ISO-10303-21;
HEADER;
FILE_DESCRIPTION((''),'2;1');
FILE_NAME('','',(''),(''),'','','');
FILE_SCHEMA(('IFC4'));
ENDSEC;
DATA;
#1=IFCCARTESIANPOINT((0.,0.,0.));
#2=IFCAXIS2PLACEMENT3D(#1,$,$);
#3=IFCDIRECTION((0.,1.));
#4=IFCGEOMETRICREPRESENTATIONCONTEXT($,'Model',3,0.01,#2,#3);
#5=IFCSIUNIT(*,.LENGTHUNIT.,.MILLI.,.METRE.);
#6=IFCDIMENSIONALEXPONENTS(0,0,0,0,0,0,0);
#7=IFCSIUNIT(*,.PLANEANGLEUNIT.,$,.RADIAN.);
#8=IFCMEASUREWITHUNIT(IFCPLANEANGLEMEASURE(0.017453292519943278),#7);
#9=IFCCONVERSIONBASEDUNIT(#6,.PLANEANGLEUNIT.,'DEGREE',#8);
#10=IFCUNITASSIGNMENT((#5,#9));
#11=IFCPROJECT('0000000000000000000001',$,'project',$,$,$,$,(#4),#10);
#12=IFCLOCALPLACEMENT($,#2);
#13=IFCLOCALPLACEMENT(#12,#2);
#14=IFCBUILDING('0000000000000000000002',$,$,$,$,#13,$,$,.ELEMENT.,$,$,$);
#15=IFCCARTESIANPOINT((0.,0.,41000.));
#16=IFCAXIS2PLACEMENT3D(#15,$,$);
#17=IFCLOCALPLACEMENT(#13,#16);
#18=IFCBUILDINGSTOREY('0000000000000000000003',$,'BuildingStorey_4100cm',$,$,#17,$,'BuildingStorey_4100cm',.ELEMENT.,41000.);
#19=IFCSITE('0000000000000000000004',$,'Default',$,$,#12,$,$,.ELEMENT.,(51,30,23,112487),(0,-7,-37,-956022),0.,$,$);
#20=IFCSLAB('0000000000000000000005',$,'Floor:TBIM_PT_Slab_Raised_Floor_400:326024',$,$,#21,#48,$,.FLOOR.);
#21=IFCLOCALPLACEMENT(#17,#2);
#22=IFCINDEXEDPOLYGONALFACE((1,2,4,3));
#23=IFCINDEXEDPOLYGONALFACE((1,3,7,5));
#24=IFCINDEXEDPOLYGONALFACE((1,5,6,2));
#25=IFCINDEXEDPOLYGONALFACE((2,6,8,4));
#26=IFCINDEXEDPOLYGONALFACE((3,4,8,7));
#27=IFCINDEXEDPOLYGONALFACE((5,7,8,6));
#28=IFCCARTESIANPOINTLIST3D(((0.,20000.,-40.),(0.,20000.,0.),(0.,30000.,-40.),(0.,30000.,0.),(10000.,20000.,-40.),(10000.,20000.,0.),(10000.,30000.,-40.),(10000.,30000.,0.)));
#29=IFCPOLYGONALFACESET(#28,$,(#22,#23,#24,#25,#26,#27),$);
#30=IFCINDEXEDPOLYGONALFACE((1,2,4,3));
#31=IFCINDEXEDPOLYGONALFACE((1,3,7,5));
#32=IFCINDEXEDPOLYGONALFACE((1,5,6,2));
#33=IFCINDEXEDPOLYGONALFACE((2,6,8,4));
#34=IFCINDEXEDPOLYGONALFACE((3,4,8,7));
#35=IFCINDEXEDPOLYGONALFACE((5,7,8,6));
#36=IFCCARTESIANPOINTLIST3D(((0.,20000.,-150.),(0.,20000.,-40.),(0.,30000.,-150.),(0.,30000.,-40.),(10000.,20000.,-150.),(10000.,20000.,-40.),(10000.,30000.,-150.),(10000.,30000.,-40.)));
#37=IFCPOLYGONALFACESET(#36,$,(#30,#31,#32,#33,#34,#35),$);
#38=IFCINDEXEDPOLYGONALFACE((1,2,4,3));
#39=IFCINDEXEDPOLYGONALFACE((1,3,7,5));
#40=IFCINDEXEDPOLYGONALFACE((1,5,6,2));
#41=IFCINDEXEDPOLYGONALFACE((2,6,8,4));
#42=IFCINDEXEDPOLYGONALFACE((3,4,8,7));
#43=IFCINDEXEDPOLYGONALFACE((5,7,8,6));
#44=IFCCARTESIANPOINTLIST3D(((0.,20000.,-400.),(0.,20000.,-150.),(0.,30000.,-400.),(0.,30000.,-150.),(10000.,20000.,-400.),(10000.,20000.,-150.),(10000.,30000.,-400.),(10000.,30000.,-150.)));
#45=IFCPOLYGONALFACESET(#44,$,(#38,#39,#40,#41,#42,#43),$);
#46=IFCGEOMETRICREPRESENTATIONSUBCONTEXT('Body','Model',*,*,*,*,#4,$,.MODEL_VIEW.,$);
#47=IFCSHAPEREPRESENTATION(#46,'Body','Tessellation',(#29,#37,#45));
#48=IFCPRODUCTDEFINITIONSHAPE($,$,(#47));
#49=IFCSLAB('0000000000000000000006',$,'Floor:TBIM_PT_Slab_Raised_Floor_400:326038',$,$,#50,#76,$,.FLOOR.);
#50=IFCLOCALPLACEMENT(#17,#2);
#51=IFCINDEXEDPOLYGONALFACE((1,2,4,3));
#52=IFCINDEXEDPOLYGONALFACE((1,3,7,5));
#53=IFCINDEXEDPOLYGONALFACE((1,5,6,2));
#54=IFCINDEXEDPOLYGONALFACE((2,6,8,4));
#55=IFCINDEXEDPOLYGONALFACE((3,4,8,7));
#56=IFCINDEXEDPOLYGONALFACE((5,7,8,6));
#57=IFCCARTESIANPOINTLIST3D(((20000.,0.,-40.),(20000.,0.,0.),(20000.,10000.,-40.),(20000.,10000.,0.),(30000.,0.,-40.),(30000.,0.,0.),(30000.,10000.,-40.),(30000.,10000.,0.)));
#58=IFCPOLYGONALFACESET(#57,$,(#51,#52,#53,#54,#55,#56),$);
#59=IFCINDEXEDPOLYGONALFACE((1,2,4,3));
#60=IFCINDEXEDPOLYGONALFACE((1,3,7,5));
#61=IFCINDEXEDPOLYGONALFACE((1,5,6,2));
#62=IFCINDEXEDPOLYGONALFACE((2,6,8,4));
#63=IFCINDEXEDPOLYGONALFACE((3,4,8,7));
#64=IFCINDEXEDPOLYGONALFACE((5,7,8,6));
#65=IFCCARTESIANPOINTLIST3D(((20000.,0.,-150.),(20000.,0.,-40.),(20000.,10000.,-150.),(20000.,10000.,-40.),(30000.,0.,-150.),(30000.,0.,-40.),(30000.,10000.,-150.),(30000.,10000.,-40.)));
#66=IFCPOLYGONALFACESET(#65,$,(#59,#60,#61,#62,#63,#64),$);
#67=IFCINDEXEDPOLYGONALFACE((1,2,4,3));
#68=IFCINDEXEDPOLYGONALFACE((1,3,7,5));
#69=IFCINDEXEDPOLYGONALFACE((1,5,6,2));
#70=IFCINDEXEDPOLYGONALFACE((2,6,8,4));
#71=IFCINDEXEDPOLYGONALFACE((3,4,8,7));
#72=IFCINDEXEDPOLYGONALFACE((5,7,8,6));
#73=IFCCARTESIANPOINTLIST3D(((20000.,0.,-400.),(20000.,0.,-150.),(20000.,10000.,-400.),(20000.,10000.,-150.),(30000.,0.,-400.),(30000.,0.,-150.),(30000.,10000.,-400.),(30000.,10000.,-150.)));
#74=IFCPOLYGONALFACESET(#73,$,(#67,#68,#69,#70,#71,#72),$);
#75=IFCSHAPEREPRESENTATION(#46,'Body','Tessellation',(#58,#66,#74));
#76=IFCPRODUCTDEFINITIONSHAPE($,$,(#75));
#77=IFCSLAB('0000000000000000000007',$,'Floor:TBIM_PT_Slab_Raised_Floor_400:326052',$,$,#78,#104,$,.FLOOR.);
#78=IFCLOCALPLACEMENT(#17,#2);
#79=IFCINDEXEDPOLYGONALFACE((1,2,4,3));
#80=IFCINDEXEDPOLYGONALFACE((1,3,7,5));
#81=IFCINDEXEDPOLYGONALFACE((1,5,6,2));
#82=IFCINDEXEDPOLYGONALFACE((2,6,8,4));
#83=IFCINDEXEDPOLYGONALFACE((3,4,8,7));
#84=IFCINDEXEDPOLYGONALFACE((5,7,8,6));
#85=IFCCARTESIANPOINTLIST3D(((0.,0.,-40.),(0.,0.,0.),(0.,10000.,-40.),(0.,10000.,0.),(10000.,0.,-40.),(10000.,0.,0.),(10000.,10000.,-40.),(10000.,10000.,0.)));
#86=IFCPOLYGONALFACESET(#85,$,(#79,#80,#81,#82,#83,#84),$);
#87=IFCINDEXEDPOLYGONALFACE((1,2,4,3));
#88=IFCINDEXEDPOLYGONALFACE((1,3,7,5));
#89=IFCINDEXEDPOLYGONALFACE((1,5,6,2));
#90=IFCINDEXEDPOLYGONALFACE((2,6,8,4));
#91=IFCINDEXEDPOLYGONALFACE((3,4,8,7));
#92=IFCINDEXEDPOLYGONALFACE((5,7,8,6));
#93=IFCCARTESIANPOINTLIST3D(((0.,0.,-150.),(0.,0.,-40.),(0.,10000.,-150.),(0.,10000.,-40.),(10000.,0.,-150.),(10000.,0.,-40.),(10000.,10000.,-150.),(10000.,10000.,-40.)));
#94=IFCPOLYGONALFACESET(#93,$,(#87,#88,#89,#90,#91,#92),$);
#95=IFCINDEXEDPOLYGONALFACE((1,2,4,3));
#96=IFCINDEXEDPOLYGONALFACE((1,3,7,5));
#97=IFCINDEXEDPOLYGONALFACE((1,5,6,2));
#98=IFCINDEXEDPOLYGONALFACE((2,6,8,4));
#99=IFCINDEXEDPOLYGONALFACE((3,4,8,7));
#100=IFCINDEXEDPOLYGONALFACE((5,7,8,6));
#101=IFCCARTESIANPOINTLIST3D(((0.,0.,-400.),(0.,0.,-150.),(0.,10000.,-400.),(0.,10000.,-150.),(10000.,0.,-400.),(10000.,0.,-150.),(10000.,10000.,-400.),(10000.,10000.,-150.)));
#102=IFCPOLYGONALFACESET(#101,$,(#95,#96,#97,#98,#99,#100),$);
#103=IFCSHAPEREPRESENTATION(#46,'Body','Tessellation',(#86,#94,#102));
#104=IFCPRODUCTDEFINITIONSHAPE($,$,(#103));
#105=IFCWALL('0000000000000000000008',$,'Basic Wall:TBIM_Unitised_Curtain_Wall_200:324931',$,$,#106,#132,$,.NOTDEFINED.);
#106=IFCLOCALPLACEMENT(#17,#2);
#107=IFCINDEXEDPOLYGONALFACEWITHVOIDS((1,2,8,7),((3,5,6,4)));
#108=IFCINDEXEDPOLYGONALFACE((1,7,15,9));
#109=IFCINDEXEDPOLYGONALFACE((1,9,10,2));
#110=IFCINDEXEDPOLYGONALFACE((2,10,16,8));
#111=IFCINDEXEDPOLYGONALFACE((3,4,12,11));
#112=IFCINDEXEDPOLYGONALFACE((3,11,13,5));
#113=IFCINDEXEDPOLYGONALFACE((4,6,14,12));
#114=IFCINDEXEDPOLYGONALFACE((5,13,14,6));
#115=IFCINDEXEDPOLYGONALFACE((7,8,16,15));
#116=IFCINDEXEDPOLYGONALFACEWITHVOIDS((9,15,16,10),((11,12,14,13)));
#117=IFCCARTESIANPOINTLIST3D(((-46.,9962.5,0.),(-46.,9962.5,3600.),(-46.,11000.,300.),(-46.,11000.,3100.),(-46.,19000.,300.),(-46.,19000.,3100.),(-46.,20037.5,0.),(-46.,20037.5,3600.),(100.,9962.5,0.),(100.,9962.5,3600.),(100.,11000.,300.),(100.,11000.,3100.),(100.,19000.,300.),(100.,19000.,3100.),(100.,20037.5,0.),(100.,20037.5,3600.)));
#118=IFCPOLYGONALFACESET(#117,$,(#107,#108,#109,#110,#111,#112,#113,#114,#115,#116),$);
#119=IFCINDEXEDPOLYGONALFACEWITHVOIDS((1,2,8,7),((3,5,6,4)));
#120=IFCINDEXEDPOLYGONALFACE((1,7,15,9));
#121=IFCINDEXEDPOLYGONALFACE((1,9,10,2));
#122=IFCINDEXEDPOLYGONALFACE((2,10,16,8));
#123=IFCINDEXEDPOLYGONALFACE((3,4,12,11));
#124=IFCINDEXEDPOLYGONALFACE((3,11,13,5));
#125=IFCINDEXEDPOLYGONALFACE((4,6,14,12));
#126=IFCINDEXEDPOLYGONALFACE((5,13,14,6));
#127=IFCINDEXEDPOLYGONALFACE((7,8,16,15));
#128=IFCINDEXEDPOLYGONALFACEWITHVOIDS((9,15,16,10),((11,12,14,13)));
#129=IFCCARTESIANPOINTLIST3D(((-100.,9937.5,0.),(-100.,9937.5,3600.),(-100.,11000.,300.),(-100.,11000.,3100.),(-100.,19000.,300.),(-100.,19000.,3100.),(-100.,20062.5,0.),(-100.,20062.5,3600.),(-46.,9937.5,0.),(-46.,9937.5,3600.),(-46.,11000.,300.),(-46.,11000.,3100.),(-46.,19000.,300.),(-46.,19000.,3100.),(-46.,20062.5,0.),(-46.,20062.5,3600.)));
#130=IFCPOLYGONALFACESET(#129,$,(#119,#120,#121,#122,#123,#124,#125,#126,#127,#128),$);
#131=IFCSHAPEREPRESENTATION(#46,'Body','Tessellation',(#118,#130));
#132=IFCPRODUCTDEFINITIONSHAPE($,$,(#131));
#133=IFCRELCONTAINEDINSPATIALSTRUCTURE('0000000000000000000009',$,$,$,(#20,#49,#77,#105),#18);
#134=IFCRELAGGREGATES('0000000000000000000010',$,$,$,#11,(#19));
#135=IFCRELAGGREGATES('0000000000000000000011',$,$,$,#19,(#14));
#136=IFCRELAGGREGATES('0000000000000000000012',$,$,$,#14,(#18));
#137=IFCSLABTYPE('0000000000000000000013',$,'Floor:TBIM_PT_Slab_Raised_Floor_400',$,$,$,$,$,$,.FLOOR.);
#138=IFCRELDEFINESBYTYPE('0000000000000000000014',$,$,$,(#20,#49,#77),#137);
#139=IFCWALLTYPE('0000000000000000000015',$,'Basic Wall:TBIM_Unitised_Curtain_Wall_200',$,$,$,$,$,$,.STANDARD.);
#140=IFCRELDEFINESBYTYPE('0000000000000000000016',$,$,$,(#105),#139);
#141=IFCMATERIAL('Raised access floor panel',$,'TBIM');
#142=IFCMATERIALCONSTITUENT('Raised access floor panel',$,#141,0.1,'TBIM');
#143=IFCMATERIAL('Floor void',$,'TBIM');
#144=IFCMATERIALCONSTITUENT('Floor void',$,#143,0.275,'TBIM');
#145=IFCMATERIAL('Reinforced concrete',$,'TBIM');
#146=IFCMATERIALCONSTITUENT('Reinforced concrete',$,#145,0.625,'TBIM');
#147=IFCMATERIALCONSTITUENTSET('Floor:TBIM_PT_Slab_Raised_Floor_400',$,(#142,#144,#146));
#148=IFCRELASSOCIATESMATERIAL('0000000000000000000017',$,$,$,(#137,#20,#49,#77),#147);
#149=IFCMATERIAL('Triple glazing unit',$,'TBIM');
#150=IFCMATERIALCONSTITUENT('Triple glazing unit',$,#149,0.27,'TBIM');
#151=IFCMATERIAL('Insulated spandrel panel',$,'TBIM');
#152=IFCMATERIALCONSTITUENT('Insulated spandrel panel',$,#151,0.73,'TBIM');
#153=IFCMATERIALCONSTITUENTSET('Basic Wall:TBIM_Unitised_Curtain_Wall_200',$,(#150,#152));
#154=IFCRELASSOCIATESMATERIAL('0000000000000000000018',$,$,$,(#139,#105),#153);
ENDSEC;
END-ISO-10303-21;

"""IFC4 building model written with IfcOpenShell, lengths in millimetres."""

from ifc_helpers import new_model, entity, si_unit, converted_unit, direction, frame, origin, place, context, subcontext, project, spatial, indexed_curve, outline, extrude, material, constituent, constituent_set, type_object, element, save


model = new_model("IFC4")

# Units and contexts
model_context = context("Model", 3, precision=0.01, world=origin(), true_north=direction((0.0, 1.0)))
body_context = subcontext(model_context, "Body", "Model", "MODEL_VIEW")
ifc_project = project(units=[si_unit("LENGTHUNIT", "METRE", prefix="MILLI"), converted_unit("PLANEANGLEUNIT", "DEGREE", entity("IfcPlaneAngleMeasure", 0.017453292519943278), si_unit("PLANEANGLEUNIT", "RADIAN"), dimensions=[0, 0, 0, 0, 0, 0, 0])], contexts=[model_context])

# Site, building, storey
site_placement = place(None, origin())
site = spatial("IfcSite", under=ifc_project, at=site_placement, Name="Default", CompositionType="ELEMENT", RefLatitude=(51, 30, 23, 112487), RefLongitude=(0, -7, -37, -956022), RefElevation=0.0)
building_placement = place(site_placement, origin())
building = spatial("IfcBuilding", under=site, at=building_placement, CompositionType="ELEMENT")
storey_placement = place(building_placement, frame((0.0, 0.0, 41000.0)))
storey = spatial("IfcBuildingStorey", under=building, at=storey_placement, Name="BuildingStorey_4100cm", LongName="BuildingStorey_4100cm", CompositionType="ELEMENT", Elevation=41000.0)

# Slabs
ifc_material_1 = material(Name="Raised access floor panel", Category="TBIM")
ifc_constituent_1 = constituent(ifc_material_1, Name="Raised access floor panel", Category="TBIM", fraction=0.1)
ifc_material_2 = material(Name="Floor void", Category="TBIM")
ifc_constituent_2 = constituent(ifc_material_2, Name="Floor void", Category="TBIM", fraction=0.275)
ifc_material_3 = material(Name="Reinforced concrete", Category="TBIM")
ifc_constituent_3 = constituent(ifc_material_3, Name="Reinforced concrete", Category="TBIM", fraction=0.625)
ifc_constituent_set_1 = constituent_set(constituents=[ifc_constituent_1, ifc_constituent_2, ifc_constituent_3], Name="Floor:TBIM_PT_Slab_Raised_Floor_400")
slab_type = type_object("IfcSlabType", Name="Floor:TBIM_PT_Slab_Raised_Floor_400", PredefinedType="FLOOR", material=ifc_constituent_set_1)
slab_1_placement = place(storey_placement, origin())
element("IfcSlab", 1, at=slab_1_placement, inside=storey, type_object=slab_type, material=ifc_constituent_set_1, Name="Floor:TBIM_PT_Slab_Raised_Floor_400:326024", PredefinedType="FLOOR", context=body_context, shape_type="SweptSolid", body=[
    extrude(outline(indexed_curve([(-5000.0, -5000.0), (5000.0, -5000.0), (5000.0, 5000.0), (-5000.0, 5000.0), (-5000.0, -5000.0)], self_intersect=False)), frame((5000.0, 25000.0, -40.0), z_axis=(0.0, 0.0, 1.0), x_axis=(-1.0, 0.0, 0.0)), (0.0, 0.0, 1.0), 40.0),
    extrude(outline(indexed_curve([(-5000.0, -5000.0), (5000.0, -5000.0), (5000.0, 5000.0), (-5000.0, 5000.0), (-5000.0, -5000.0)], self_intersect=False)), frame((5000.0, 25000.0, -150.0), z_axis=(0.0, 0.0, 1.0), x_axis=(-1.0, 0.0, 0.0)), (0.0, 0.0, 1.0), 110.0),
    extrude(outline(indexed_curve([(-5000.0, -5000.0), (5000.0, -5000.0), (5000.0, 5000.0), (-5000.0, 5000.0), (-5000.0, -5000.0)], self_intersect=False)), frame((5000.0, 25000.0, -400.0), z_axis=(0.0, 0.0, 1.0), x_axis=(-1.0, 0.0, 0.0)), (0.0, 0.0, 1.0), 250.0),
])
slab_2_placement = place(storey_placement, origin())
element("IfcSlab", 2, at=slab_2_placement, inside=storey, type_object=slab_type, material=ifc_constituent_set_1, Name="Floor:TBIM_PT_Slab_Raised_Floor_400:326038", PredefinedType="FLOOR", context=body_context, shape_type="SweptSolid", body=[
    extrude(outline(indexed_curve([(-5000.0, -5000.0), (5000.0, -5000.0), (5000.0, 5000.0), (-5000.0, 5000.0), (-5000.0, -5000.0)], self_intersect=False)), frame((25000.0, 5000.0, -40.0), z_axis=(0.0, 0.0, 1.0), x_axis=(-1.0, 0.0, 0.0)), (0.0, 0.0, 1.0), 40.0),
    extrude(outline(indexed_curve([(-5000.0, -5000.0), (5000.0, -5000.0), (5000.0, 5000.0), (-5000.0, 5000.0), (-5000.0, -5000.0)], self_intersect=False)), frame((25000.0, 5000.0, -150.0), z_axis=(0.0, 0.0, 1.0), x_axis=(-1.0, 0.0, 0.0)), (0.0, 0.0, 1.0), 110.0),
    extrude(outline(indexed_curve([(-5000.0, -5000.0), (5000.0, -5000.0), (5000.0, 5000.0), (-5000.0, 5000.0), (-5000.0, -5000.0)], self_intersect=False)), frame((25000.0, 5000.0, -400.0), z_axis=(0.0, 0.0, 1.0), x_axis=(-1.0, 0.0, 0.0)), (0.0, 0.0, 1.0), 250.0),
])
slab_3_placement = place(storey_placement, origin())
element("IfcSlab", 3, at=slab_3_placement, inside=storey, type_object=slab_type, material=ifc_constituent_set_1, Name="Floor:TBIM_PT_Slab_Raised_Floor_400:326052", PredefinedType="FLOOR", context=body_context, shape_type="SweptSolid", body=[
    extrude(outline(indexed_curve([(-5000.0, -5000.0), (5000.0, -5000.0), (5000.0, 5000.0), (-5000.0, 5000.0), (-5000.0, -5000.0)], self_intersect=False)), frame((5000.0, 5000.0, -40.0), z_axis=(0.0, 0.0, 1.0), x_axis=(-1.0, 0.0, 0.0)), (0.0, 0.0, 1.0), 40.0),
    extrude(outline(indexed_curve([(-5000.0, -5000.0), (5000.0, -5000.0), (5000.0, 5000.0), (-5000.0, 5000.0), (-5000.0, -5000.0)], self_intersect=False)), frame((5000.0, 5000.0, -150.0), z_axis=(0.0, 0.0, 1.0), x_axis=(-1.0, 0.0, 0.0)), (0.0, 0.0, 1.0), 110.0),
    extrude(outline(indexed_curve([(-5000.0, -5000.0), (5000.0, -5000.0), (5000.0, 5000.0), (-5000.0, 5000.0), (-5000.0, -5000.0)], self_intersect=False)), frame((5000.0, 5000.0, -400.0), z_axis=(0.0, 0.0, 1.0), x_axis=(-1.0, 0.0, 0.0)), (0.0, 0.0, 1.0), 250.0),
])

# Wall, opening
ifc_material_4 = material(Name="Triple glazing unit", Category="TBIM")
ifc_constituent_4 = constituent(ifc_material_4, Name="Triple glazing unit", Category="TBIM", fraction=0.27)
ifc_material_5 = material(Name="Insulated spandrel panel", Category="TBIM")
ifc_constituent_5 = constituent(ifc_material_5, Name="Insulated spandrel panel", Category="TBIM", fraction=0.73)
ifc_constituent_set_2 = constituent_set(constituents=[ifc_constituent_4, ifc_constituent_5], Name="Basic Wall:TBIM_Unitised_Curtain_Wall_200")
wall_type = type_object("IfcWallType", Name="Basic Wall:TBIM_Unitised_Curtain_Wall_200", PredefinedType="STANDARD", material=ifc_constituent_set_2)
wall_1_placement = place(storey_placement, frame((0.0, 9937.5, 0.0), z_axis=(0.0, 0.0, 1.0), x_axis=(0.0, 1.0, 0.0)))
wall_1 = element("IfcWall", 4, at=wall_1_placement, inside=storey, type_object=wall_type, material=ifc_constituent_set_2, Name="Basic Wall:TBIM_Unitised_Curtain_Wall_200:324931", PredefinedType="NOTDEFINED", context=body_context, shape_type="SweptSolid", body=[
    extrude(outline(indexed_curve([(-1800.0, -5037.5), (1800.0, -5037.5), (1800.0, 5037.5), (-1800.0, 5037.5), (-1800.0, -5037.5)], self_intersect=False), holes=[indexed_curve([(1300.0, 4000.0), (1300.0, -4000.0), (-1500.0, -4000.0), (-1500.0, 4000.0), (1300.0, 4000.0)], self_intersect=False)]), frame((5062.5, 46.0, 1800.0), z_axis=(0.0, -1.0, 0.0), x_axis=(0.0, 0.0, 1.0)), (0.0, 0.0, 1.0), 146.0),
    extrude(outline(indexed_curve([(-5062.5, -1800.0), (5062.5, -1800.0), (5062.5, 1800.0), (-5062.5, 1800.0), (-5062.5, -1800.0)], self_intersect=False), holes=[indexed_curve([(-4000.0, 1300.0), (4000.0, 1300.0), (4000.0, -1500.0), (-4000.0, -1500.0), (-4000.0, 1300.0)], self_intersect=False)]), frame((5062.5, 100.0, 1800.0), z_axis=(0.0, -1.0, 0.0), x_axis=(1.0, 0.0, 0.0)), (0.0, 0.0, 1.0), 54.0),
])
opening_1_placement = place(wall_1_placement, frame((1062.5, -100.0, 300.0)))
element("IfcOpeningElement", 5, at=opening_1_placement, cuts=wall_1, PredefinedType="OPENING", context=body_context, shape_type="SweptSolid", body=[
    extrude(outline(indexed_curve([(2800.0, 0.0), (2800.0, 8000.0), (0.0, 8000.0), (0.0, 0.0), (2800.0, 0.0)], self_intersect=False)), frame((0.0, 0.0, 0.0), z_axis=(0.0, 1.0, 0.0), x_axis=(0.0, 0.0, 1.0)), (0.0, 0.0, 1.0), 200.0),
])

save(model, "model.ifc")
